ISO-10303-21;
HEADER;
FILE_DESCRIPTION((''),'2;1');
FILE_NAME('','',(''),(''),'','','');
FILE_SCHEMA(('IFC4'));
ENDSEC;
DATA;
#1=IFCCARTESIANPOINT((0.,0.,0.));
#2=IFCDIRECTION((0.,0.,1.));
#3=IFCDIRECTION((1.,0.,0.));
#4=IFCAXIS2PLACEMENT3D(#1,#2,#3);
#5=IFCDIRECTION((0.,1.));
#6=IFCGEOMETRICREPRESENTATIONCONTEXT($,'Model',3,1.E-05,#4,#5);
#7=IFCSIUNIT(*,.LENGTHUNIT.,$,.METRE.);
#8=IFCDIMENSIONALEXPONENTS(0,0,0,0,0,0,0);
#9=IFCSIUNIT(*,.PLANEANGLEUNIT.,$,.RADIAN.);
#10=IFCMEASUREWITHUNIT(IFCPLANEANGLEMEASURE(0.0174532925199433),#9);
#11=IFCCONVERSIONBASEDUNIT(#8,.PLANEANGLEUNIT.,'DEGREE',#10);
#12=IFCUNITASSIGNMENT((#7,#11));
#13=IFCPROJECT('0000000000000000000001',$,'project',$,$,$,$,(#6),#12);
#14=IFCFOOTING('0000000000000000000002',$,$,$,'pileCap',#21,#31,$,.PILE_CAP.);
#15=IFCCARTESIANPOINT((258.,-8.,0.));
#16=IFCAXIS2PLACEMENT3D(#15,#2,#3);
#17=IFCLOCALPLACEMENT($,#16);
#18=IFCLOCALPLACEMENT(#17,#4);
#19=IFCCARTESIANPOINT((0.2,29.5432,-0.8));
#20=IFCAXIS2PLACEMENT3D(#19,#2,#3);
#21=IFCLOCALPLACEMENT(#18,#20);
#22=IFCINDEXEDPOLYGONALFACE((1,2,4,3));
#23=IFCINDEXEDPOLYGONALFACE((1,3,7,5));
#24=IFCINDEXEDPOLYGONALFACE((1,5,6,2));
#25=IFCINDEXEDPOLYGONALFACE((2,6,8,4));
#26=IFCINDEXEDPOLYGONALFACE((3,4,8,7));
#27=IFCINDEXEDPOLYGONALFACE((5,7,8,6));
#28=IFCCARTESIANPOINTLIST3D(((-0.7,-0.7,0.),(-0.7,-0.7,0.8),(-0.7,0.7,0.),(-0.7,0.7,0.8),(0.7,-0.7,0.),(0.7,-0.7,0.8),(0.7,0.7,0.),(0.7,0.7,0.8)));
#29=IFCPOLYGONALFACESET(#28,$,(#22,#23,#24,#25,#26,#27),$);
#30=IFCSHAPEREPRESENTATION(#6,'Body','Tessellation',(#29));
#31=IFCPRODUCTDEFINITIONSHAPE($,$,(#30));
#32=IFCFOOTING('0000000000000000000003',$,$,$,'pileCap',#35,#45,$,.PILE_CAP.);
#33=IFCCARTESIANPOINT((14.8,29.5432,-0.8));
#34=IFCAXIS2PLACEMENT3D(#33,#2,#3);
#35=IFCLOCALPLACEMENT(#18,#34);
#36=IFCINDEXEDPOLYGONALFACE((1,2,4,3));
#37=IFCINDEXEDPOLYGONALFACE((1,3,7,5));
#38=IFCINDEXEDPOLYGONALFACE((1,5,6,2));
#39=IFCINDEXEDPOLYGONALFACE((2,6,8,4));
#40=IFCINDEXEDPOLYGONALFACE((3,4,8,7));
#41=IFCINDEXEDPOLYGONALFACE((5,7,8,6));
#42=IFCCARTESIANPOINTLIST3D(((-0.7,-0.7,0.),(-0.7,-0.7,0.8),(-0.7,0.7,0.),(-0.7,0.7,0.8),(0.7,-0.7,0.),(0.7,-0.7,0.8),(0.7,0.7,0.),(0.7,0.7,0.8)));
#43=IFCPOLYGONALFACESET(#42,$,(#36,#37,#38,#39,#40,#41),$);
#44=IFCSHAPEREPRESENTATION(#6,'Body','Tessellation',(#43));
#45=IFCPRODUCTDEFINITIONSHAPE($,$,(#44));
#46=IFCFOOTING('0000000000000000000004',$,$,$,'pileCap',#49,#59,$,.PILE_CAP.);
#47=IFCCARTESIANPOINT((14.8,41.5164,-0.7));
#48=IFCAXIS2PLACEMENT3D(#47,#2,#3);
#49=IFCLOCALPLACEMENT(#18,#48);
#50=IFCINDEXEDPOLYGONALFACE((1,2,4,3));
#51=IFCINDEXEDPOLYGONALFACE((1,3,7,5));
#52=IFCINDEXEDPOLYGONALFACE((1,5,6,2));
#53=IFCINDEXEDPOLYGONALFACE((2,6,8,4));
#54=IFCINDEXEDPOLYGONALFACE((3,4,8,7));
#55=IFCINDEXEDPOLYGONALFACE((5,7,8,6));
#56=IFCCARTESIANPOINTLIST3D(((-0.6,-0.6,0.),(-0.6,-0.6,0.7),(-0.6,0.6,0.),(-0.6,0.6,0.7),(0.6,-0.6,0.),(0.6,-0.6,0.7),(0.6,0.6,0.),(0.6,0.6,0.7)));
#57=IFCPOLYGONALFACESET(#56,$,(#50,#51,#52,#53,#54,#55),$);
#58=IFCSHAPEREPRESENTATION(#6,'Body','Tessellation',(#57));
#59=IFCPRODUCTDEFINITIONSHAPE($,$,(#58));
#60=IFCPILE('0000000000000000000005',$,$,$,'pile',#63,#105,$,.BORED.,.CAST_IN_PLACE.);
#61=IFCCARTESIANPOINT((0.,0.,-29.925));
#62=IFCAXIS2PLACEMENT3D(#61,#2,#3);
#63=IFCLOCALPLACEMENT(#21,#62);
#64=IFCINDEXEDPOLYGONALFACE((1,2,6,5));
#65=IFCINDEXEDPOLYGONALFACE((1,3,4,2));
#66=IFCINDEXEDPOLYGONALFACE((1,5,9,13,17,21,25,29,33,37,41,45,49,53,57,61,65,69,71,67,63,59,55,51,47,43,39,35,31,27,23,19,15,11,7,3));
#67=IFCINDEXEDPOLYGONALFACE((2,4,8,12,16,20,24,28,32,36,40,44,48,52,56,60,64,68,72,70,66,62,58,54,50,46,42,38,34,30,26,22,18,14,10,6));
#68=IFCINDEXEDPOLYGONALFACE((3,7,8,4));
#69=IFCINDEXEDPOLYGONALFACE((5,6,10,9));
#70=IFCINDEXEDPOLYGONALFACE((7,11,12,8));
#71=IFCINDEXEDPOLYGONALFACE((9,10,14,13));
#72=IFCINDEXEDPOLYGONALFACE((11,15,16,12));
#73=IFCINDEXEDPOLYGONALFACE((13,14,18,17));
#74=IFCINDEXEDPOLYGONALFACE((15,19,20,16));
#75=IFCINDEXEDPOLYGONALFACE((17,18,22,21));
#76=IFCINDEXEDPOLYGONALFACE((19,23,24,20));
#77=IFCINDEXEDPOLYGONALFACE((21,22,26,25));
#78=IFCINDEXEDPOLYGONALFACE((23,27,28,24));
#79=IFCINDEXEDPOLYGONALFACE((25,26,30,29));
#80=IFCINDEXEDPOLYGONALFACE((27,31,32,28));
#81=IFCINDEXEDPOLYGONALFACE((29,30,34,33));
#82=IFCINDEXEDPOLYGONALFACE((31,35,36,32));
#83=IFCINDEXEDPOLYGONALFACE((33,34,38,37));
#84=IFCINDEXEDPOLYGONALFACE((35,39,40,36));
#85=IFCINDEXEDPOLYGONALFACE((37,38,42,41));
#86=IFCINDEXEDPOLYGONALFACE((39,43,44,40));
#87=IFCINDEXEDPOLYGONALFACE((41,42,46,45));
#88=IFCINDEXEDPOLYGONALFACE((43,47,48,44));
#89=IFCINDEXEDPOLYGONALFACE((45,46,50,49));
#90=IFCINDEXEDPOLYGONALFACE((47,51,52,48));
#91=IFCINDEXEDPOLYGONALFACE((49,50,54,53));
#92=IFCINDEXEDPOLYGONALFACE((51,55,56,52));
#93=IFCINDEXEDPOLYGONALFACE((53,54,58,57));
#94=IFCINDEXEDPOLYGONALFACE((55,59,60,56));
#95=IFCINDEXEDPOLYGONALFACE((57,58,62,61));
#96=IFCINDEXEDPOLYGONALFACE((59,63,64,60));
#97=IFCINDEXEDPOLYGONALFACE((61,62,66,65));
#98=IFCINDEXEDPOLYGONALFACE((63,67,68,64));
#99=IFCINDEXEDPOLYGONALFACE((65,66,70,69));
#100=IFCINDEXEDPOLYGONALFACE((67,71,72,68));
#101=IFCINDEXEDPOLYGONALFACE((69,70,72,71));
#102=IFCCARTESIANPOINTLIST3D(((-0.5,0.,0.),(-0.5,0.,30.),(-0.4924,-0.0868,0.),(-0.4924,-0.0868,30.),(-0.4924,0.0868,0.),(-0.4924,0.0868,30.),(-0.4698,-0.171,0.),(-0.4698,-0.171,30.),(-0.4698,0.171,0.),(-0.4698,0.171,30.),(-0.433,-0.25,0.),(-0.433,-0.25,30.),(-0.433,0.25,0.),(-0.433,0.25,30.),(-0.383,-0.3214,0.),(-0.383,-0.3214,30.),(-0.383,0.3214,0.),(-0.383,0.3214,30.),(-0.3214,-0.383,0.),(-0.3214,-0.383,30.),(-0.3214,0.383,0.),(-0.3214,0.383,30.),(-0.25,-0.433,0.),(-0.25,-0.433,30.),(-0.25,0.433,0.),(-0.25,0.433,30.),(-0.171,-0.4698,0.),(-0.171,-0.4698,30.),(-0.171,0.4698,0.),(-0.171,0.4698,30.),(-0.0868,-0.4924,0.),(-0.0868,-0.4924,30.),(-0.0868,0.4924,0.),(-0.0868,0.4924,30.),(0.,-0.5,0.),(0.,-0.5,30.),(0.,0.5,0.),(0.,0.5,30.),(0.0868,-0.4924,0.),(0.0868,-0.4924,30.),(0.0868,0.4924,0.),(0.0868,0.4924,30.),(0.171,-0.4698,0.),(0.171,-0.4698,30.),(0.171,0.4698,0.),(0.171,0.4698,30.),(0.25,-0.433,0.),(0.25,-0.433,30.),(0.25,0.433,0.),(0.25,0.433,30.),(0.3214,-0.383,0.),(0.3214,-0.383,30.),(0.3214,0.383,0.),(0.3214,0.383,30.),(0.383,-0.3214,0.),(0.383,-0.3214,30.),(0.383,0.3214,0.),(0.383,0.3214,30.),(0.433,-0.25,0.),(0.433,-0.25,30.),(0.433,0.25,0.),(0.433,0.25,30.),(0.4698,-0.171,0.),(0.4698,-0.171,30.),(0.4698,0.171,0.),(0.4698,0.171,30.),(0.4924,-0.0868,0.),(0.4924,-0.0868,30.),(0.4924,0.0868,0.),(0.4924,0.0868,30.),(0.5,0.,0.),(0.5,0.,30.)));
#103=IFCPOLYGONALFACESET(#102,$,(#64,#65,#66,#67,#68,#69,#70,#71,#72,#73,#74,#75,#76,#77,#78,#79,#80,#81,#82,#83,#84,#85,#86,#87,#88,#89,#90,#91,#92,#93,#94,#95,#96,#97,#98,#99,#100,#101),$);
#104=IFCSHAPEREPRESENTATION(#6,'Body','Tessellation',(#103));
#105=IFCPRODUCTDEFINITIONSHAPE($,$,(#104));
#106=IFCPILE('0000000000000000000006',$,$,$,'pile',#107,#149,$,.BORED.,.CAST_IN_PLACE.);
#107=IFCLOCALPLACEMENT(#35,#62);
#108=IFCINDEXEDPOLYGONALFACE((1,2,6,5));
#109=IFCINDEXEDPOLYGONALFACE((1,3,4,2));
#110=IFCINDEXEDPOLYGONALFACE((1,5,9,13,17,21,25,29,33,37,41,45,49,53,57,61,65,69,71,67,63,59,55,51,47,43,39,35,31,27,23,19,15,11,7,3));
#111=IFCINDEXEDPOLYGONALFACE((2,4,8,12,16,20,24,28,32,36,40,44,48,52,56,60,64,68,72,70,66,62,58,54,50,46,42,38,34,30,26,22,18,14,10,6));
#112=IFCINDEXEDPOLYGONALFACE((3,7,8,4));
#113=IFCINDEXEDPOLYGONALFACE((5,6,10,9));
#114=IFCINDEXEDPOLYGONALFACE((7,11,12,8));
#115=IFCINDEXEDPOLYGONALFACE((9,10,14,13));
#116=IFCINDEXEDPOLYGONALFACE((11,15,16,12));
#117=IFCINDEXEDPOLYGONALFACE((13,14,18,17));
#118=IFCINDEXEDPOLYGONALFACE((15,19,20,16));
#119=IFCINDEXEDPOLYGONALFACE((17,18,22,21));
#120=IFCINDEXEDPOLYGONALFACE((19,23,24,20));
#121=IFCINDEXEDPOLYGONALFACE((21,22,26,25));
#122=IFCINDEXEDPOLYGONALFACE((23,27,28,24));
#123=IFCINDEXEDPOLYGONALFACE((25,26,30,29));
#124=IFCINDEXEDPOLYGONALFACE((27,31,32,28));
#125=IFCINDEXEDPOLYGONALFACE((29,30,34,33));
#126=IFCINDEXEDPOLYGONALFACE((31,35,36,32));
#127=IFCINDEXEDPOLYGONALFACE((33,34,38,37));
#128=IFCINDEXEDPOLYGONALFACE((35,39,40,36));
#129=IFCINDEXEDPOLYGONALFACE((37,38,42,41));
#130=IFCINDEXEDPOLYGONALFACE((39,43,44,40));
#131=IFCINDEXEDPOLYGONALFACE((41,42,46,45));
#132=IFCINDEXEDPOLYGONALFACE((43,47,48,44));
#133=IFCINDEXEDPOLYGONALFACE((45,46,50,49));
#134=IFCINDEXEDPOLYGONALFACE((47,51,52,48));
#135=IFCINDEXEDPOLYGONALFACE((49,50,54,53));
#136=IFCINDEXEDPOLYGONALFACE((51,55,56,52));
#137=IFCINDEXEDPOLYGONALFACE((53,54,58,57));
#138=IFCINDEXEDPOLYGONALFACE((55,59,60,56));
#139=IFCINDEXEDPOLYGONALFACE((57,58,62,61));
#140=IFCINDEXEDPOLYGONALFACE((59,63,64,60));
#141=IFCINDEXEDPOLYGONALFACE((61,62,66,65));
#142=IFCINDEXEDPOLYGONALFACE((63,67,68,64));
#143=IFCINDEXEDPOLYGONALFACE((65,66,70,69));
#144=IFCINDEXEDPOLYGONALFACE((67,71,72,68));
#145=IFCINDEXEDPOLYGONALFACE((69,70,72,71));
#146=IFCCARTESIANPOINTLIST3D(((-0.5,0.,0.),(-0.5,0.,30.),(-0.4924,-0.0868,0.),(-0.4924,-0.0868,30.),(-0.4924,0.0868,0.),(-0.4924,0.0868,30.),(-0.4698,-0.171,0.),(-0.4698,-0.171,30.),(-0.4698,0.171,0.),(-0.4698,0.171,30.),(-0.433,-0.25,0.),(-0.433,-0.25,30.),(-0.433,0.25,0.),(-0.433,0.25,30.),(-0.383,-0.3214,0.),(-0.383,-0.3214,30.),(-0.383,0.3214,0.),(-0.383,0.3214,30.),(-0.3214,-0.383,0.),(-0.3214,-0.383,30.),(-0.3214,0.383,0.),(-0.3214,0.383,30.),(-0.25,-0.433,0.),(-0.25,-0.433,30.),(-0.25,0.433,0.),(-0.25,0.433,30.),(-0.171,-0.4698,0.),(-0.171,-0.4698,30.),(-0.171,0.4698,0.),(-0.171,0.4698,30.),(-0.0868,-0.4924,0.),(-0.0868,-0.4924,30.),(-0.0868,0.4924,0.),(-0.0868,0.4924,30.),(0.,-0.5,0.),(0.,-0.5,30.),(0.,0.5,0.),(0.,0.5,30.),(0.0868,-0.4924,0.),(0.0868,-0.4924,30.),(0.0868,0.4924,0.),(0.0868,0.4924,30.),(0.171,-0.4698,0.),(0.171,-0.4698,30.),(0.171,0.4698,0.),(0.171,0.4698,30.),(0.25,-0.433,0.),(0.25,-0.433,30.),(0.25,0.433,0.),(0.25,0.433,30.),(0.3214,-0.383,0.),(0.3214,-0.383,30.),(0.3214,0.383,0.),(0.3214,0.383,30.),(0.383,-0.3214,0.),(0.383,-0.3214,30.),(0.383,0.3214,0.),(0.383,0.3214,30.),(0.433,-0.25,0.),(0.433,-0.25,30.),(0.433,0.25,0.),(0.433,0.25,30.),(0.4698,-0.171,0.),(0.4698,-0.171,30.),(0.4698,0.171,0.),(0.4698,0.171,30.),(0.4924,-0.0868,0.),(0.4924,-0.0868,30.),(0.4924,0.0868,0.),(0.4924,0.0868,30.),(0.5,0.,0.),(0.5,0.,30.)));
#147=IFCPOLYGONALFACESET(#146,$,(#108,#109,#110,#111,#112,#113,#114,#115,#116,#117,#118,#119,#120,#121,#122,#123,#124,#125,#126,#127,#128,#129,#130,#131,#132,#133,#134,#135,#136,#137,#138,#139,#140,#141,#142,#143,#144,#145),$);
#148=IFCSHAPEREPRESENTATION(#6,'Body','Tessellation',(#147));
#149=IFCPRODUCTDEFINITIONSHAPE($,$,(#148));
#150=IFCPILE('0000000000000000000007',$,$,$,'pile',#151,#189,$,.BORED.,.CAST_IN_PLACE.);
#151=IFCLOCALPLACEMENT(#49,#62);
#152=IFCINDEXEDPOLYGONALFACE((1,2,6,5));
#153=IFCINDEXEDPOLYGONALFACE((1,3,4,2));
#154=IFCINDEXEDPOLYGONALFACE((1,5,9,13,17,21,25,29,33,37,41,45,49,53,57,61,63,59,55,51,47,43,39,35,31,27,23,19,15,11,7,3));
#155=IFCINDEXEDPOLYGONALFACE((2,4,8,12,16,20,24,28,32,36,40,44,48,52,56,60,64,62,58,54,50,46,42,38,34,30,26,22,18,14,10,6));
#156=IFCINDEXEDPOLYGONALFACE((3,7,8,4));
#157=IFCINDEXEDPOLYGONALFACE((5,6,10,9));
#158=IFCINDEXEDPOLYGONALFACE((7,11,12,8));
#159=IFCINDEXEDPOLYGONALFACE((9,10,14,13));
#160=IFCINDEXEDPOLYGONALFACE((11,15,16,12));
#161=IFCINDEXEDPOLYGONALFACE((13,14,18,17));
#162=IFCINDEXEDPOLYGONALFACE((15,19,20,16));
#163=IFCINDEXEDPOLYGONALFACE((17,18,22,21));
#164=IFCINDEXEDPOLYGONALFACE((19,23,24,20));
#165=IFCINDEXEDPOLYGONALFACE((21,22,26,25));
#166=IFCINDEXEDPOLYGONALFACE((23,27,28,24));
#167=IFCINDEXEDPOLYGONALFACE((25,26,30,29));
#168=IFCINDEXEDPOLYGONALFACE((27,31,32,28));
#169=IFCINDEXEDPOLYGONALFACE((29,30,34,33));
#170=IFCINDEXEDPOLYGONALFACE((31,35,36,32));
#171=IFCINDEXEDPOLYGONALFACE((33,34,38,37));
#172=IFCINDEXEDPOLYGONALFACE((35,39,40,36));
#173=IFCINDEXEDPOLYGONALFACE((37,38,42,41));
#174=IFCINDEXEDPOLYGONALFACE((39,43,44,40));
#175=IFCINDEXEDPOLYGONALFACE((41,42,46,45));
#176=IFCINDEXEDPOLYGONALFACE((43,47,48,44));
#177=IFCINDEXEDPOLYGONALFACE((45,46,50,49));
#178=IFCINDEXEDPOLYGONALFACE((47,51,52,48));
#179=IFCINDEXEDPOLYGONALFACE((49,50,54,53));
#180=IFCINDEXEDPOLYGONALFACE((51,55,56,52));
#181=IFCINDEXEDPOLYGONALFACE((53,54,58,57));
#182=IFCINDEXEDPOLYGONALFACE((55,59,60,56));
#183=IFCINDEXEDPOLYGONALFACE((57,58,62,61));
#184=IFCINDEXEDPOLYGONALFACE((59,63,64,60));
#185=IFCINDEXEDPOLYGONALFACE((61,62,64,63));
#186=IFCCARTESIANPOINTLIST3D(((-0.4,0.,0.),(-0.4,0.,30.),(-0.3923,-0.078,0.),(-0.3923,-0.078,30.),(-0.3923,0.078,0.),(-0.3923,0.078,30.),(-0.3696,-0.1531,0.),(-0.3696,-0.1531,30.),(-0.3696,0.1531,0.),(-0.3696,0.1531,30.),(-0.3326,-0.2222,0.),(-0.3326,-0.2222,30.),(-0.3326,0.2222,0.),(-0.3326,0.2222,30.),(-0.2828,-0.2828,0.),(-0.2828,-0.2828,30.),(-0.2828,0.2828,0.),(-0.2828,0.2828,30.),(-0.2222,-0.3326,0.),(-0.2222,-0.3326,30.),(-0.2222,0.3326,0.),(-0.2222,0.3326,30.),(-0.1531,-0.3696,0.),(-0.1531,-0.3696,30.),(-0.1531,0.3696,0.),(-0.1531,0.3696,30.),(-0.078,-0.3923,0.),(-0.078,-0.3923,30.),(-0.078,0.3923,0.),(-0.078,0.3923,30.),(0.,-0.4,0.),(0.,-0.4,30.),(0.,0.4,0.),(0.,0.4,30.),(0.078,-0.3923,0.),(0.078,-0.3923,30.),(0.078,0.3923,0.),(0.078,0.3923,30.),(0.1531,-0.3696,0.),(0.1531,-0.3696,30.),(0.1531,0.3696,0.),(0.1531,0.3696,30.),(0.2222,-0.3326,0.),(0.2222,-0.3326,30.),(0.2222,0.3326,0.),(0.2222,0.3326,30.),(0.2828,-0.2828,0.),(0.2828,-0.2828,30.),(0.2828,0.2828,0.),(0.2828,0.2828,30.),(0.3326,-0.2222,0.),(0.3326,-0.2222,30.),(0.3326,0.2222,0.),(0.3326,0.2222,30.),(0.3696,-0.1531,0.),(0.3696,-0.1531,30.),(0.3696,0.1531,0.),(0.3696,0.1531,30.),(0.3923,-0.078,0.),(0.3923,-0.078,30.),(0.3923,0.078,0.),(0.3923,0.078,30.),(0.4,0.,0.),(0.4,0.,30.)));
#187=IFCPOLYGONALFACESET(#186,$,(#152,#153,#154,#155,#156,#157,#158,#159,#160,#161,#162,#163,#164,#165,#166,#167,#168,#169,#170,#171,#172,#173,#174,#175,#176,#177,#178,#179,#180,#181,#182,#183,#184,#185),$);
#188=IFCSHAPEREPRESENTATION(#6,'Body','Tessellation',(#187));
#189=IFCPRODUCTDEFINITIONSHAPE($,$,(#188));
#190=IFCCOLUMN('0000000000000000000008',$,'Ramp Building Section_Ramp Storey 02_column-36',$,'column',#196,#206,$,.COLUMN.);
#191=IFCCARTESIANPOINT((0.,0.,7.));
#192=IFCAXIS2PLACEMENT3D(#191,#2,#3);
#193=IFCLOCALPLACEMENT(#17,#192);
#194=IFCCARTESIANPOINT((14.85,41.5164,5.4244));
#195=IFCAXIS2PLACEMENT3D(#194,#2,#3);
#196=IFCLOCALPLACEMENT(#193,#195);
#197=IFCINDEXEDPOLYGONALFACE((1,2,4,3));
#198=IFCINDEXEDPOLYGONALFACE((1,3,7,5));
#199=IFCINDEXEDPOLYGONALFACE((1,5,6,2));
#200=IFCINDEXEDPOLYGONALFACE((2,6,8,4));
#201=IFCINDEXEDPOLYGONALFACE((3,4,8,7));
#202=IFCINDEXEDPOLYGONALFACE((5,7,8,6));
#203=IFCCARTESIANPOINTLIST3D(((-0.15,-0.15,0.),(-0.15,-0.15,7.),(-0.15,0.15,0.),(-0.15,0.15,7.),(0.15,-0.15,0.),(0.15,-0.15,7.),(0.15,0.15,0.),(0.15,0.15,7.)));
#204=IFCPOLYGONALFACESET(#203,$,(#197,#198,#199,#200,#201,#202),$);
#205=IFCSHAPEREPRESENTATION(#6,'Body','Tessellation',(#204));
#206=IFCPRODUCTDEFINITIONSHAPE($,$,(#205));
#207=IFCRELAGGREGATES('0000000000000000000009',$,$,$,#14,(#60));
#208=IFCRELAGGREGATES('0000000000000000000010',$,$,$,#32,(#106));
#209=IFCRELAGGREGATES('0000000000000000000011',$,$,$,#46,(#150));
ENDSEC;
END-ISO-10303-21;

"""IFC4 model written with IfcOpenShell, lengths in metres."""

from ifc_helpers import new_model, entity, si_unit, converted_unit, direction, frame, origin_with_axes, place, context, project, polyline, circle_curve, parameter, trimmed, segment, composite_curve, outline, extrude, element, aggregate, save


model = new_model("IFC4")

# Units and contexts
model_context = context("Model", 3, precision=1e-05, world=origin_with_axes(), true_north=direction((0.0, 1.0)))
ifc_project = project(units=[si_unit("LENGTHUNIT", "METRE"), converted_unit("PLANEANGLEUNIT", "DEGREE", entity("IfcPlaneAngleMeasure", 0.0174532925199433), si_unit("PLANEANGLEUNIT", "RADIAN"), dimensions=[0, 0, 0, 0, 0, 0, 0])], contexts=[model_context])

# Footings
placement_1 = place(None, frame((258.0, -8.0, 0.0), z_axis=(0.0, 0.0, 1.0), x_axis=(1.0, 0.0, 0.0)))
placement_2 = place(placement_1, origin_with_axes())
footing_1_placement = place(placement_2, frame((0.2, 29.5432, -0.8), z_axis=(0.0, 0.0, 1.0), x_axis=(1.0, 0.0, 0.0)))
footing_1 = element("IfcFooting", 1, at=footing_1_placement, ObjectType="pileCap", PredefinedType="PILE_CAP", context=model_context, body=[
    extrude(outline(polyline([(0.7, -0.7, 0.0), (0.7, 0.7, 0.0), (-0.7, 0.7, 0.0), (-0.7, -0.7, 0.0), (0.7, -0.7, 0.0)])), origin_with_axes(), (0.0, 0.0, 1.0), 0.8),
])
footing_2_placement = place(placement_2, frame((14.8, 29.5432, -0.8), z_axis=(0.0, 0.0, 1.0), x_axis=(1.0, 0.0, 0.0)))
footing_2 = element("IfcFooting", 2, at=footing_2_placement, ObjectType="pileCap", PredefinedType="PILE_CAP", context=model_context, body=[
    extrude(outline(polyline([(0.7, -0.7, 0.0), (0.7, 0.7, 0.0), (-0.7, 0.7, 0.0), (-0.7, -0.7, 0.0), (0.7, -0.7, 0.0)])), origin_with_axes(), (0.0, 0.0, 1.0), 0.8),
])
footing_3_placement = place(placement_2, frame((14.8, 41.5164, -0.7), z_axis=(0.0, 0.0, 1.0), x_axis=(1.0, 0.0, 0.0)))
footing_3 = element("IfcFooting", 3, at=footing_3_placement, ObjectType="pileCap", PredefinedType="PILE_CAP", context=model_context, body=[
    extrude(outline(polyline([(0.6, -0.6, 0.0), (0.6, 0.6, 0.0), (-0.6, 0.6, 0.0), (-0.6, -0.6, 0.0), (0.6, -0.6, 0.0)])), origin_with_axes(), (0.0, 0.0, 1.0), 0.7),
])

# Piles
pile_1_placement = place(footing_1_placement, frame((0.0, 0.0, -29.925), z_axis=(0.0, 0.0, 1.0), x_axis=(1.0, 0.0, 0.0)))
pile_1 = element("IfcPile", 4, at=pile_1_placement, ObjectType="pile", ConstructionType="CAST_IN_PLACE", PredefinedType="BORED", context=model_context, body=[
    extrude(outline(composite_curve([segment(trimmed(circle_curve(origin_with_axes(), 0.5), [parameter(0.0)], [parameter(360.0)], True, "PARAMETER"), True, "CONTINUOUS")], self_intersect=False)), origin_with_axes(), (0.0, 0.0, 1.0), 30.0),
])
aggregate(footing_1, [pile_1])
pile_2_placement = place(footing_2_placement, frame((0.0, 0.0, -29.925), z_axis=(0.0, 0.0, 1.0), x_axis=(1.0, 0.0, 0.0)))
pile_2 = element("IfcPile", 5, at=pile_2_placement, ObjectType="pile", ConstructionType="CAST_IN_PLACE", PredefinedType="BORED", context=model_context, body=[
    extrude(outline(composite_curve([segment(trimmed(circle_curve(origin_with_axes(), 0.5), [parameter(0.0)], [parameter(360.0)], True, "PARAMETER"), True, "CONTINUOUS")], self_intersect=False)), origin_with_axes(), (0.0, 0.0, 1.0), 30.0),
])
aggregate(footing_2, [pile_2])
pile_3_placement = place(footing_3_placement, frame((0.0, 0.0, -29.925), z_axis=(0.0, 0.0, 1.0), x_axis=(1.0, 0.0, 0.0)))
pile_3 = element("IfcPile", 6, at=pile_3_placement, ObjectType="pile", ConstructionType="CAST_IN_PLACE", PredefinedType="BORED", context=model_context, body=[
    extrude(outline(composite_curve([segment(trimmed(circle_curve(origin_with_axes(), 0.4), [parameter(0.0)], [parameter(360.0)], True, "PARAMETER"), True, "CONTINUOUS")], self_intersect=False)), origin_with_axes(), (0.0, 0.0, 1.0), 30.0),
])
aggregate(footing_3, [pile_3])

# Column
placement_3 = place(placement_1, frame((0.0, 0.0, 7.0), z_axis=(0.0, 0.0, 1.0), x_axis=(1.0, 0.0, 0.0)))
column_1_placement = place(placement_3, frame((14.85, 41.5164, 5.4244), z_axis=(0.0, 0.0, 1.0), x_axis=(1.0, 0.0, 0.0)))
element("IfcColumn", 7, at=column_1_placement, Name="Ramp Building Section_Ramp Storey 02_column-36", ObjectType="column", PredefinedType="COLUMN", context=model_context, body=[
    extrude(outline(polyline([(-0.15, -0.15, 0.0), (0.15, -0.15, 0.0), (0.15, 0.15, 0.0), (-0.15, 0.15, 0.0), (-0.15, -0.15, 0.0)])), origin_with_axes(), (0.0, 0.0, 1.0), 7.0),
])

save(model, "model.ifc")
